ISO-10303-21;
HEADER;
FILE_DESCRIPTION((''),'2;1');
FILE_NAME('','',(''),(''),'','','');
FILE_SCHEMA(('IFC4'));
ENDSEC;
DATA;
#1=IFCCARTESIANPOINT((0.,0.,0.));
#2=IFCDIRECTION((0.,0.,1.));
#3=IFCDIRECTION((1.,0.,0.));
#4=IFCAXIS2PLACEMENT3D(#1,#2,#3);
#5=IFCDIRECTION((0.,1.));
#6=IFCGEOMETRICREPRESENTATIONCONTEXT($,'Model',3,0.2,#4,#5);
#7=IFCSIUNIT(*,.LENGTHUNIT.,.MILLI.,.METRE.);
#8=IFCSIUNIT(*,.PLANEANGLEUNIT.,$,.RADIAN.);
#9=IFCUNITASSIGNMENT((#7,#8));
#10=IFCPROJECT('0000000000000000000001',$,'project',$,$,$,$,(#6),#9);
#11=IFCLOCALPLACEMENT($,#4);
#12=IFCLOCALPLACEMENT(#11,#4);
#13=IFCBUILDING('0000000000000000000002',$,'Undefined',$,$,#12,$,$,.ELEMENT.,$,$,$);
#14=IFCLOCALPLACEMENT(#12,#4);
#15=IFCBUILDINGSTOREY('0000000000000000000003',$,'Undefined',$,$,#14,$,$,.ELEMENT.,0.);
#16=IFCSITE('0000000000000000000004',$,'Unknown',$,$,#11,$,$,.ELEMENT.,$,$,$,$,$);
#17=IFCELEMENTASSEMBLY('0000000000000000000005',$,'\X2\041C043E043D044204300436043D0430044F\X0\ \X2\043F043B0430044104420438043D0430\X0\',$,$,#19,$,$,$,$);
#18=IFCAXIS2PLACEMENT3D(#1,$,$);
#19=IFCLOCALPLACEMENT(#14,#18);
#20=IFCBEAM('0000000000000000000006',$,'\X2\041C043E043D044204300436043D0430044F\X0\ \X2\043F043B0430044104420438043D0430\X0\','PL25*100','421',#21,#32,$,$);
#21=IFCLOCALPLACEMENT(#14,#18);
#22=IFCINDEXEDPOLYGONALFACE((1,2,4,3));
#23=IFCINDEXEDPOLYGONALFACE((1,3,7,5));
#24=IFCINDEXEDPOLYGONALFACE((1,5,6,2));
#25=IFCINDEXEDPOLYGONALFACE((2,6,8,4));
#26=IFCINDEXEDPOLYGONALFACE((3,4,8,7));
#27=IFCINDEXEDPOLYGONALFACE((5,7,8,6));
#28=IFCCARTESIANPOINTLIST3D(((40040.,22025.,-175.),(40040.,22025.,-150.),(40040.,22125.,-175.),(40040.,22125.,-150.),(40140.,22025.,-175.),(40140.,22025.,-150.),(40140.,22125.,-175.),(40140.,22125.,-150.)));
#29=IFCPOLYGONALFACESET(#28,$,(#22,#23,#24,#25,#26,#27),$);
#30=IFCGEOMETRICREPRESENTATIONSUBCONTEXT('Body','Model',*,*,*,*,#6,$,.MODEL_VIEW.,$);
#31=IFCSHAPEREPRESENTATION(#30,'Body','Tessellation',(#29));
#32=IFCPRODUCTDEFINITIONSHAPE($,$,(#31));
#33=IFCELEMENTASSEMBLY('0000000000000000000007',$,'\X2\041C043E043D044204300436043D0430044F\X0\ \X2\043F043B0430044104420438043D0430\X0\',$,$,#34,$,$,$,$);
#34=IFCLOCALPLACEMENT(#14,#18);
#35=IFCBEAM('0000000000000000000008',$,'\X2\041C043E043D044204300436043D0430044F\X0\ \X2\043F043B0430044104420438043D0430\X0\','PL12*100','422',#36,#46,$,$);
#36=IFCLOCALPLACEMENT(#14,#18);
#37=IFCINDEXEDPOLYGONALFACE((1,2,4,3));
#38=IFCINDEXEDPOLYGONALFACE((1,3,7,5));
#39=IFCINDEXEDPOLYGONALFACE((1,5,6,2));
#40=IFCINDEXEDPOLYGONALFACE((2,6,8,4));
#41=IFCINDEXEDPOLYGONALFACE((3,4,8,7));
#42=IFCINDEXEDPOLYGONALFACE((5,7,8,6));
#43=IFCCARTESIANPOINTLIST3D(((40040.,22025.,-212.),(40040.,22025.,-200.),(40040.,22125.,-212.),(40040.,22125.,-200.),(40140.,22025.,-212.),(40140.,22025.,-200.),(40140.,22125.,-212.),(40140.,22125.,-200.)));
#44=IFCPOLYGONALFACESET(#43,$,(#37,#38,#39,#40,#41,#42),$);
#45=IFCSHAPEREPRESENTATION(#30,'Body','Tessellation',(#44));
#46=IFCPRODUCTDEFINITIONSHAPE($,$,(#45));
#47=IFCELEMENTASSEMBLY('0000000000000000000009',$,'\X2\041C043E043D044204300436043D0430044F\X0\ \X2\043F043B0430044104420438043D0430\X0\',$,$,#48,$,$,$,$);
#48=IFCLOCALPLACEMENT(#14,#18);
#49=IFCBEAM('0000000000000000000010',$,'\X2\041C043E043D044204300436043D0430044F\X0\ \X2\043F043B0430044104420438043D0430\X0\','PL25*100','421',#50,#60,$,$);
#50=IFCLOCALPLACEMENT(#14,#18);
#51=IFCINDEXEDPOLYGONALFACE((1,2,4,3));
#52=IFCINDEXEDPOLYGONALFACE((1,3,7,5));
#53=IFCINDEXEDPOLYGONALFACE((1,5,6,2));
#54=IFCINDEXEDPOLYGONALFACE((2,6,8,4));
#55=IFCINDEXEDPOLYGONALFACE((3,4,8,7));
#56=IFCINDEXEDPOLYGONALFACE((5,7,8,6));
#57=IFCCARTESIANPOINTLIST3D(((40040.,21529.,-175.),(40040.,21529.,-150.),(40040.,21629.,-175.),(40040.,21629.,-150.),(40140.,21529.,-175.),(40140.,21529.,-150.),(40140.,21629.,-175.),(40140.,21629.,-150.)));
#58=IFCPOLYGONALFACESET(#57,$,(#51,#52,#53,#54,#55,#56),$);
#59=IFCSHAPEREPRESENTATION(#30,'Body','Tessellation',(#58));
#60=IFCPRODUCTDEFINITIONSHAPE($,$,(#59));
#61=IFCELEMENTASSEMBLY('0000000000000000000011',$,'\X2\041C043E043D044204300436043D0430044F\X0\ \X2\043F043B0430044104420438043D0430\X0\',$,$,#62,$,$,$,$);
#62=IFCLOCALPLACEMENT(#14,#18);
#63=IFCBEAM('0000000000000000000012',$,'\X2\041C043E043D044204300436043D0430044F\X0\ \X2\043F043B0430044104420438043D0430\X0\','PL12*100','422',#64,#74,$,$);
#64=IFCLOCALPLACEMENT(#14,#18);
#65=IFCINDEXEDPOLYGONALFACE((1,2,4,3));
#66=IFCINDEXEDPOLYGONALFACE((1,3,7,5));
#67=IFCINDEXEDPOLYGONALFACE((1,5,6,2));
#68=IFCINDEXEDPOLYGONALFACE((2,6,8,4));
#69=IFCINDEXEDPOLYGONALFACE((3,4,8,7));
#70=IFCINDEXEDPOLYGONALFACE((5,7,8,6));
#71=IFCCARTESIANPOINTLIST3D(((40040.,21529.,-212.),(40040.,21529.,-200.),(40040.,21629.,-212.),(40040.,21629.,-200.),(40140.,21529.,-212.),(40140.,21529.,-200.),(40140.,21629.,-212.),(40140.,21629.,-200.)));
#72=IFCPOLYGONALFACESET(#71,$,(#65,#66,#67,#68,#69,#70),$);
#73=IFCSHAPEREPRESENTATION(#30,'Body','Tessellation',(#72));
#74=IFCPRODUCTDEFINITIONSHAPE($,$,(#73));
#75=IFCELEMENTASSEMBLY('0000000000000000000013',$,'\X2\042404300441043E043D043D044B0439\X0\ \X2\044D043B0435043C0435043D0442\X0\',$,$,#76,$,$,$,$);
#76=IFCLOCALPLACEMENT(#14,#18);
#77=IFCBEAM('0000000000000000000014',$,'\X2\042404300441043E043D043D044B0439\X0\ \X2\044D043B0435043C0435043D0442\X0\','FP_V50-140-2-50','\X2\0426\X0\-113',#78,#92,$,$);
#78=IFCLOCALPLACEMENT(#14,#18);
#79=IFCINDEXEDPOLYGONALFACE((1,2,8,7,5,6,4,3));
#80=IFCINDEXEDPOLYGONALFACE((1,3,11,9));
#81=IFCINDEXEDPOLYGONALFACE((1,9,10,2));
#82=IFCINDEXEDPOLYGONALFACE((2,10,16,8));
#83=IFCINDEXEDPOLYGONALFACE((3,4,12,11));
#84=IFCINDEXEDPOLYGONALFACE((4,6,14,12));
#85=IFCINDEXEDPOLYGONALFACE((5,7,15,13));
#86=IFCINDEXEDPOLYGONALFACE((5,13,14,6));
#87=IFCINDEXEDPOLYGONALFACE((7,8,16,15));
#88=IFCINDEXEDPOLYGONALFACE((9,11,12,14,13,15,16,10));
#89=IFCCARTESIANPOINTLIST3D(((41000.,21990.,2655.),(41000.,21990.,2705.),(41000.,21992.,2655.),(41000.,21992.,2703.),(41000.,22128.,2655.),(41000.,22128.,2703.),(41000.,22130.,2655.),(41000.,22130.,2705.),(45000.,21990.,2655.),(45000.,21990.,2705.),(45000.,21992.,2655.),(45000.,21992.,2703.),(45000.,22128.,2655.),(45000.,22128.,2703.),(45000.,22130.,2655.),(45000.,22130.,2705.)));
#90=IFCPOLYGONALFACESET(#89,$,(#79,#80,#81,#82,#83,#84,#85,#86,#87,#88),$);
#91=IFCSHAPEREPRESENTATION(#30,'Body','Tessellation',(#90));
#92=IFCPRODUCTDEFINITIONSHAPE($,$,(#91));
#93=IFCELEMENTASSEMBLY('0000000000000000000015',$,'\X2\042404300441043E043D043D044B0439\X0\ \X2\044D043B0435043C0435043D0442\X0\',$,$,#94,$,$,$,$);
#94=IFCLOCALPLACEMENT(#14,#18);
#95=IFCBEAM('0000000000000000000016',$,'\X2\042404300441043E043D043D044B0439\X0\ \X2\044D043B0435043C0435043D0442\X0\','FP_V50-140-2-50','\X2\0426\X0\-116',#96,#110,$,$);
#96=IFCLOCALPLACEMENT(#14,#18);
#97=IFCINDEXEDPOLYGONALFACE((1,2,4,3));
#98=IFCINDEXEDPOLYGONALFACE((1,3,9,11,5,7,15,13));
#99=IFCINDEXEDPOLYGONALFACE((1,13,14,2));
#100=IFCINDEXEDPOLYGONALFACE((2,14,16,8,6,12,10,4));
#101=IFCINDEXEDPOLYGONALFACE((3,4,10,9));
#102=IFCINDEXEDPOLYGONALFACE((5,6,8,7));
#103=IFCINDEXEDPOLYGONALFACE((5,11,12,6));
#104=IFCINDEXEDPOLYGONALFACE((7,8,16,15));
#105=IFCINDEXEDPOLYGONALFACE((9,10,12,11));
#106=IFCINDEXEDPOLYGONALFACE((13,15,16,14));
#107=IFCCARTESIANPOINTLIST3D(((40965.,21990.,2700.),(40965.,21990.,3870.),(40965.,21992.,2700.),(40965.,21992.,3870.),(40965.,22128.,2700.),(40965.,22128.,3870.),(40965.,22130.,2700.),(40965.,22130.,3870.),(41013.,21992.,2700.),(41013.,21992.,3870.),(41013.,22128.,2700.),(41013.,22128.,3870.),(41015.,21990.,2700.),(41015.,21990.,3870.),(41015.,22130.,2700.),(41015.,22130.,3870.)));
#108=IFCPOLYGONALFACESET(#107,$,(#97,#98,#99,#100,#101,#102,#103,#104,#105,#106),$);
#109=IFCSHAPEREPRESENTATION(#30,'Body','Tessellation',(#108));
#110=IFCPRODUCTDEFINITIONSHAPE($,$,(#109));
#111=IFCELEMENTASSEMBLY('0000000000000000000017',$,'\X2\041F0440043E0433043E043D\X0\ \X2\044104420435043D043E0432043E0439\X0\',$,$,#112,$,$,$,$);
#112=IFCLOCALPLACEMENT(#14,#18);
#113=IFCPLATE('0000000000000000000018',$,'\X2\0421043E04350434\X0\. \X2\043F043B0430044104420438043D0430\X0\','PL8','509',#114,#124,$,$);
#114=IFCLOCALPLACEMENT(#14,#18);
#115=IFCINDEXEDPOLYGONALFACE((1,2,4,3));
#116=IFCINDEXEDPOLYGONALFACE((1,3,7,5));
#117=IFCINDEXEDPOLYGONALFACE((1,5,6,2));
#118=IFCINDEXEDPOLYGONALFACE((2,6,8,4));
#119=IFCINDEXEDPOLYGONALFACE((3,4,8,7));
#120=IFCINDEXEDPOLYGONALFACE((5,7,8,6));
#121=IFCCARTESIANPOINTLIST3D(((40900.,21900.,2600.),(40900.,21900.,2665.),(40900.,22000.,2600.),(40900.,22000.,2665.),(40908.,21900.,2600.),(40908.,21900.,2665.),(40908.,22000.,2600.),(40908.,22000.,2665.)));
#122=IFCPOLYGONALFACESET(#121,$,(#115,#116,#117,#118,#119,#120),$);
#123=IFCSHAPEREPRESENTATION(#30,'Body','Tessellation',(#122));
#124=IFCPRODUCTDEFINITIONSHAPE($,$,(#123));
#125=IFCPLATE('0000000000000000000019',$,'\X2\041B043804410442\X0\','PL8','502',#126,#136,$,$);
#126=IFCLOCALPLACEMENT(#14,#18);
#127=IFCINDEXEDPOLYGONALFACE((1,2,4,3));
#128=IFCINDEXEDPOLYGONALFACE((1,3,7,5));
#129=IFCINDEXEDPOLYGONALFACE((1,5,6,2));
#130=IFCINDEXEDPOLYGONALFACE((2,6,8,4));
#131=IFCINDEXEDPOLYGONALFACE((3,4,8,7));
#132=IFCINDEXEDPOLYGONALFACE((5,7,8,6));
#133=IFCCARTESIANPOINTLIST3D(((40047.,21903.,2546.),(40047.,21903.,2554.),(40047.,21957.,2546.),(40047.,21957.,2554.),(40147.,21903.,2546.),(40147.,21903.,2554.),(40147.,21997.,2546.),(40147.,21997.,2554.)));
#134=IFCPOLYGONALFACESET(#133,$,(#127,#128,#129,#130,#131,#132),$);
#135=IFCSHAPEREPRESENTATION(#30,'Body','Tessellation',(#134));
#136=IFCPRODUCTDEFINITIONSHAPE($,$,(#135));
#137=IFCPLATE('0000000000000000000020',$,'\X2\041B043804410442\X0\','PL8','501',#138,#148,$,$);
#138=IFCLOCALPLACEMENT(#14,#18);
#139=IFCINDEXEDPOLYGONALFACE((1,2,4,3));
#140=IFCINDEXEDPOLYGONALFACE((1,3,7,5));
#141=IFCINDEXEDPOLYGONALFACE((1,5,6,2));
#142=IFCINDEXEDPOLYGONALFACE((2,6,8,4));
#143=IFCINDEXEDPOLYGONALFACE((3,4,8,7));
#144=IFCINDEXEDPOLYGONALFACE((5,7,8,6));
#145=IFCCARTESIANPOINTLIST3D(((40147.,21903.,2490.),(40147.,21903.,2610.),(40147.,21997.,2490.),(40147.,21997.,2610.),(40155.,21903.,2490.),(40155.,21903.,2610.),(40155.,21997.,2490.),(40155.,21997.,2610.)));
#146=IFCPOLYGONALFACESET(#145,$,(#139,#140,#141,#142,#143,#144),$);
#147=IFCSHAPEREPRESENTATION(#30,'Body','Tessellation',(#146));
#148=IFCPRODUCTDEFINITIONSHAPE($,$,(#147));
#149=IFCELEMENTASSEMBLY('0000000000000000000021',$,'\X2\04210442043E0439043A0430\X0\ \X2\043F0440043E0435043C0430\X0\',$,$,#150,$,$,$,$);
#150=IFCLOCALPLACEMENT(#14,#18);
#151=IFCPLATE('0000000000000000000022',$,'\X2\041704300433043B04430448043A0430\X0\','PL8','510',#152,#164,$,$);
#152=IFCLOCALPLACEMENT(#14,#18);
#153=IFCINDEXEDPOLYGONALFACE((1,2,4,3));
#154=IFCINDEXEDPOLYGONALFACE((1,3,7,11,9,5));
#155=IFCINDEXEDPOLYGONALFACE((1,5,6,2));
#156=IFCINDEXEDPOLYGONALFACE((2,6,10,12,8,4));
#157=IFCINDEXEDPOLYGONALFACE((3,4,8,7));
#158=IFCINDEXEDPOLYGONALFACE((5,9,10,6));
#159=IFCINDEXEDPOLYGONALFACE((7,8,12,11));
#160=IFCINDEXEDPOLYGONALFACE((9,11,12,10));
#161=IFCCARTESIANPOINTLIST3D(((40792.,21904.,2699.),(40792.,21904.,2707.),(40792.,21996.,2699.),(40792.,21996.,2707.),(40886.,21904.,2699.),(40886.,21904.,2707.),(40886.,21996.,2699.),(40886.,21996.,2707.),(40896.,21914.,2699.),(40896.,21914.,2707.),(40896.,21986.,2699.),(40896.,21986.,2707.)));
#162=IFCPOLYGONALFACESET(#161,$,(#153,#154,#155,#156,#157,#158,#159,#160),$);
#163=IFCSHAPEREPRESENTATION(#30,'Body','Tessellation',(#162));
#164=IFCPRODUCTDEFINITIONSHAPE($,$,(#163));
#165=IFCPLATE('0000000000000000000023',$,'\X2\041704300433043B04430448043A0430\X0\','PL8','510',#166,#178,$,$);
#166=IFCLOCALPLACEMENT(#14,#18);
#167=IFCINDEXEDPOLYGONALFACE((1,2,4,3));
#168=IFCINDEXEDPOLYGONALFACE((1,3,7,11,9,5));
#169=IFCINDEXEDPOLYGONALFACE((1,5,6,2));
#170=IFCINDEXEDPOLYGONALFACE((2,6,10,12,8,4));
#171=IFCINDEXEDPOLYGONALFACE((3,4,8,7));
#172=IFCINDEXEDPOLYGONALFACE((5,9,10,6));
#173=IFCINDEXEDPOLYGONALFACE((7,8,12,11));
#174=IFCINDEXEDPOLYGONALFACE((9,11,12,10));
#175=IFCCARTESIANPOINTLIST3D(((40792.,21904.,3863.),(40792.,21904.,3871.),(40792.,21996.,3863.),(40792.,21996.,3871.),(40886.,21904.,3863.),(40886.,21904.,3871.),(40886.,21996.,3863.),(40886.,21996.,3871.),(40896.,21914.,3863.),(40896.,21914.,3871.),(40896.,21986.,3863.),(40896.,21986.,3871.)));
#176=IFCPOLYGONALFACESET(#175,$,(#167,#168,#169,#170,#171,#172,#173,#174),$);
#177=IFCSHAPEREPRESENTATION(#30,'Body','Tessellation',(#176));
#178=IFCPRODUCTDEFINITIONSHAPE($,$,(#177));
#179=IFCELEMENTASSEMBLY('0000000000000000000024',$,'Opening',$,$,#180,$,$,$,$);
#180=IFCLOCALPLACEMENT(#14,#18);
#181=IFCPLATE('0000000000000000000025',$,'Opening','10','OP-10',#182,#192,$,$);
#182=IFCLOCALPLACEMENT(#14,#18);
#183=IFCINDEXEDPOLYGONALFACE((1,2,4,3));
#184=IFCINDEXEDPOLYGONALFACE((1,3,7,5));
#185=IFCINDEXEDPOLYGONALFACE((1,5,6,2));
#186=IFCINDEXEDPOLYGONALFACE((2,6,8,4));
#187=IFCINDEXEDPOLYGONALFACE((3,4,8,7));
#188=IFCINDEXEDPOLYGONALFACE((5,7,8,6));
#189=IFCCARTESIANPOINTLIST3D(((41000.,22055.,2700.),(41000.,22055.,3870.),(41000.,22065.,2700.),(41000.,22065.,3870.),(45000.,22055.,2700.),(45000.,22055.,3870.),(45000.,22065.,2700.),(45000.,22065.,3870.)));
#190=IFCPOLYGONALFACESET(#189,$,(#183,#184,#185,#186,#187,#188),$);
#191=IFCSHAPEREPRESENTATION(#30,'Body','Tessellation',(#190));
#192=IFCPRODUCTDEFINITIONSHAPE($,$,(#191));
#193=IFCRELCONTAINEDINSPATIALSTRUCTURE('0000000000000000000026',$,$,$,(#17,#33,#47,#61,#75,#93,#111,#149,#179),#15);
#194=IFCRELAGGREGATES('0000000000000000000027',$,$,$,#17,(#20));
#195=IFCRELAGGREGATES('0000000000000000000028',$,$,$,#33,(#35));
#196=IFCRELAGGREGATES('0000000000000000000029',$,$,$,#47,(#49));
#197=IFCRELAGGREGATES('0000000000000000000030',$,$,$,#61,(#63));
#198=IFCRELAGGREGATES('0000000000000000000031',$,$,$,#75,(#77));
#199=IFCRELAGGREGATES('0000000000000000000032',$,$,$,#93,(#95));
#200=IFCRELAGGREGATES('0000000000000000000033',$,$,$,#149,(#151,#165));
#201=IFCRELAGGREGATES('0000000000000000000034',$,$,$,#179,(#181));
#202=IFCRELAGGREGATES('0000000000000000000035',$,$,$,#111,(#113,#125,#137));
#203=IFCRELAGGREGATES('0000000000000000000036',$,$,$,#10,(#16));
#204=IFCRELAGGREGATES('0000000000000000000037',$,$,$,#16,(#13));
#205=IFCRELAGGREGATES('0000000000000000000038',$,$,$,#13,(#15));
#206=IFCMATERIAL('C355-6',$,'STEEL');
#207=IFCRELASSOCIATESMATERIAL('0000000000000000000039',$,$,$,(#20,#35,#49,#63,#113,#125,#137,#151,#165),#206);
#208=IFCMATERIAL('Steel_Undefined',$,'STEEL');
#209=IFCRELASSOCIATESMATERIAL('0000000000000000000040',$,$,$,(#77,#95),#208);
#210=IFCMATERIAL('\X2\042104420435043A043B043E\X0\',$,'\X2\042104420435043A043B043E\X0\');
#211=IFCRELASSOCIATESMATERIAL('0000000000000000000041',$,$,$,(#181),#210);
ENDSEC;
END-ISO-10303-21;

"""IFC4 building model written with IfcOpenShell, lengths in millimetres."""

from ifc_helpers import new_model, si_unit, direction, frame, origin_with_axes, place, context, subcontext, project, spatial, line, indexed_curve, outline, extrude, material, element, aggregate, save


model = new_model("IFC4")

# Units and contexts
model_context = context("Model", 3, precision=0.2, world=origin_with_axes(), true_north=direction((0.0, 1.0)))
body_context = subcontext(model_context, "Body", "Model", "MODEL_VIEW")
ifc_project = project(units=[si_unit("LENGTHUNIT", "METRE", prefix="MILLI"), si_unit("PLANEANGLEUNIT", "RADIAN")], contexts=[model_context])

# Site, building, storey
site_placement = place(None, origin_with_axes())
site = spatial("IfcSite", under=ifc_project, at=site_placement, Name="Unknown", CompositionType="ELEMENT")
building_placement = place(site_placement, origin_with_axes())
building = spatial("IfcBuilding", under=site, at=building_placement, Name="Undefined", CompositionType="ELEMENT")
storey_placement = place(building_placement, origin_with_axes())
storey = spatial("IfcBuildingStorey", under=building, at=storey_placement, Name="Undefined", CompositionType="ELEMENT", Elevation=0.0)

# Shared definitions
ifc_material_1 = material(Name="Steel_Undefined", Category="STEEL")

# Element assemblies, beams
assembly_1_placement = place(storey_placement, frame((40140.0, 22075.0, -162.5), z_axis=(0.0, 0.0, -1.0), x_axis=(-1.0, 0.0, 0.0)))
assembly_1 = element("IfcElementAssembly", 1, at=assembly_1_placement, inside=storey, Name="Монтажная пластина")
ifc_material_2 = material(Name="C355-6", Category="STEEL")
beam_1_placement = place(assembly_1_placement, origin_with_axes())
beam_1 = element("IfcBeam", 2, at=beam_1_placement, material=ifc_material_2, Name="Монтажная пластина", Description="PL25*100", ObjectType="421", context=body_context, shape_type="SolidModel", body=[
    extrude(outline(indexed_curve([(-12.5, -50.0), (12.5, -50.0), (12.5, 50.0), (-12.5, 50.0)], segments=[line(1, 2, 3, 4, 1)])), frame((0.0, 0.0, 0.0), z_axis=(-1.0, 0.0, 0.0), x_axis=(0.0, 0.0, 1.0)), (0.0, 0.0, -1.0), 100.0),
])
aggregate(assembly_1, [beam_1])
assembly_2_placement = place(storey_placement, frame((40140.0, 22075.0, -206.0), z_axis=(0.0, 0.0, -1.0), x_axis=(-1.0, 0.0, 0.0)))
assembly_2 = element("IfcElementAssembly", 3, at=assembly_2_placement, inside=storey, Name="Монтажная пластина")
beam_2_placement = place(assembly_2_placement, origin_with_axes())
beam_2 = element("IfcBeam", 4, at=beam_2_placement, material=ifc_material_2, Name="Монтажная пластина", Description="PL12*100", ObjectType="422", context=body_context, shape_type="SolidModel", body=[
    extrude(outline(indexed_curve([(-6.0, -50.0), (6.0, -50.0), (6.0, 50.0), (-6.0, 50.0)], segments=[line(1, 2, 3, 4, 1)])), frame((0.0, 0.0, 0.0), z_axis=(-1.0, 0.0, 0.0), x_axis=(0.0, 0.0, 1.0)), (0.0, 0.0, -1.0), 100.0),
])
aggregate(assembly_2, [beam_2])
assembly_3_placement = place(storey_placement, frame((40140.0, 21579.0, -162.5), z_axis=(0.0, 0.0, -1.0), x_axis=(-1.0, 0.0, 0.0)))
assembly_3 = element("IfcElementAssembly", 5, at=assembly_3_placement, inside=storey, Name="Монтажная пластина")
beam_3_placement = place(assembly_3_placement, origin_with_axes())
beam_3 = element("IfcBeam", 6, at=beam_3_placement, material=ifc_material_2, Name="Монтажная пластина", Description="PL25*100", ObjectType="421", context=body_context, shape_type="SolidModel", body=[
    extrude(outline(indexed_curve([(-12.5, -50.0), (12.5, -50.0), (12.5, 50.0), (-12.5, 50.0)], segments=[line(1, 2, 3, 4, 1)])), frame((0.0, 0.0, 0.0), z_axis=(-1.0, 0.0, 0.0), x_axis=(0.0, 0.0, 1.0)), (0.0, 0.0, -1.0), 100.0),
])
aggregate(assembly_3, [beam_3])
assembly_4_placement = place(storey_placement, frame((40140.0, 21579.0, -206.0), z_axis=(0.0, 0.0, -1.0), x_axis=(-1.0, 0.0, 0.0)))
assembly_4 = element("IfcElementAssembly", 7, at=assembly_4_placement, inside=storey, Name="Монтажная пластина")
beam_4_placement = place(assembly_4_placement, origin_with_axes())
beam_4 = element("IfcBeam", 8, at=beam_4_placement, material=ifc_material_2, Name="Монтажная пластина", Description="PL12*100", ObjectType="422", context=body_context, shape_type="SolidModel", body=[
    extrude(outline(indexed_curve([(-6.0, -50.0), (6.0, -50.0), (6.0, 50.0), (-6.0, 50.0)], segments=[line(1, 2, 3, 4, 1)])), frame((0.0, 0.0, 0.0), z_axis=(-1.0, 0.0, 0.0), x_axis=(0.0, 0.0, 1.0)), (0.0, 0.0, -1.0), 100.0),
])
aggregate(assembly_4, [beam_4])
assembly_5_placement = place(storey_placement, frame((45000.0, 22060.0, 2680.0), z_axis=(0.0, 1.0, 0.0), x_axis=(-1.0, 0.0, 0.0)))
assembly_5 = element("IfcElementAssembly", 9, at=assembly_5_placement, inside=storey, Name="Фасонный элемент")
beam_5_placement = place(assembly_5_placement, origin_with_axes())
beam_5 = element("IfcBeam", 10, at=beam_5_placement, material=ifc_material_1, Name="Фасонный элемент", Description="FP_V50-140-2-50", ObjectType="Ц-113", context=body_context, shape_type="SolidModel", body=[
    extrude(outline(indexed_curve([(-70.0, -25.0), (-68.0, -25.0), (-68.0, 23.0), (68.0, 23.0), (68.0, -25.0), (70.0, -25.0), (70.0, 25.0), (-70.0, 25.0)], segments=[line(1, 2, 3, 4, 5, 6, 7, 8, 1)])), frame((0.0, 0.0, 0.0), z_axis=(-1.0, 0.0, 0.0), x_axis=(0.0, 0.0, 1.0)), (0.0, 0.0, -1.0), 4000.0),
])
aggregate(assembly_5, [beam_5])
assembly_6_placement = place(storey_placement, frame((40990.0, 22060.0, 3870.0), z_axis=(0.0, -1.0, 0.0), x_axis=(0.0, 0.0, -1.0)))
assembly_6 = element("IfcElementAssembly", 11, at=assembly_6_placement, inside=storey, Name="Фасонный элемент")
beam_6_placement = place(assembly_6_placement, origin_with_axes())
beam_6 = element("IfcBeam", 12, at=beam_6_placement, material=ifc_material_1, Name="Фасонный элемент", Description="FP_V50-140-2-50", ObjectType="Ц-116", context=body_context, shape_type="SolidModel", body=[
    extrude(outline(indexed_curve([(-70.0, -25.0), (-68.0, -25.0), (-68.0, 23.0), (68.0, 23.0), (68.0, -25.0), (70.0, -25.0), (70.0, 25.0), (-70.0, 25.0)], segments=[line(1, 2, 3, 4, 5, 6, 7, 8, 1)])), frame((0.0, 0.0, 0.0), z_axis=(-1.0, 0.0, 0.0), x_axis=(0.0, 0.0, 1.0)), (0.0, 0.0, -1.0), 1170.0),
])
aggregate(assembly_6, [beam_6])

# Element assemblies, plates
assembly_7_placement = place(storey_placement, frame((46000.0, 21950.0, 2550.0), z_axis=(0.0, 0.0, -1.0), x_axis=(-1.0, 0.0, 0.0)))
assembly_7 = element("IfcElementAssembly", 13, at=assembly_7_placement, inside=storey, Name="Прогон стеновой")
plate_1_placement = place(assembly_7_placement, frame((5096.0, 50.0, -50.0), z_axis=(-1.0, 0.0, 0.0), x_axis=(0.0, 0.0, -1.0)))
plate_1 = element("IfcPlate", 14, at=plate_1_placement, material=ifc_material_2, Name="Соед. пластина", Description="PL8", ObjectType="509", context=body_context, shape_type="SolidModel", body=[
    extrude(outline(indexed_curve([(0.0, 0.0), (65.0, 0.0), (65.0, 100.0), (0.0, 100.0)], segments=[line(1, 2, 3, 4, 1)])), frame((0.0, 0.0, 4.0), z_axis=(0.0, 0.0, 1.0), x_axis=(1.0, 0.0, 0.0)), (0.0, 0.0, -1.0), 8.0),
])
plate_2_placement = place(assembly_7_placement, frame((5853.0, 47.0, 0.0), z_axis=(0.0, 0.0, 1.0), x_axis=(0.0, -1.0, 0.0)))
plate_2 = element("IfcPlate", 15, at=plate_2_placement, material=ifc_material_2, Name="Лист", Description="PL8", ObjectType="502", context=body_context, shape_type="SolidModel", body=[
    extrude(outline(indexed_curve([(0.0, 0.0), (94.0, 0.0), (94.0, 100.0), (40.0, 100.0), (0.0, 0.0)], segments=[line(1, 2, 3, 4, 5, 1)])), frame((0.0, 0.0, 4.0), z_axis=(0.0, 0.0, 1.0), x_axis=(1.0, 0.0, 0.0)), (0.0, 0.0, -1.0), 8.0),
])
plate_3_placement = place(assembly_7_placement, frame((5849.0, 47.0, -60.0), z_axis=(-1.0, 0.0, 0.0), x_axis=(0.0, -1.0, 0.0)))
plate_3 = element("IfcPlate", 16, at=plate_3_placement, material=ifc_material_2, Name="Лист", Description="PL8", ObjectType="501", context=body_context, shape_type="SolidModel", body=[
    extrude(outline(indexed_curve([(0.0, 0.0), (94.0, 0.0), (94.0, 120.0), (0.0, 120.0)], segments=[line(1, 2, 3, 4, 1)])), frame((0.0, 0.0, 4.0), z_axis=(0.0, 0.0, 1.0), x_axis=(1.0, 0.0, 0.0)), (0.0, 0.0, -1.0), 8.0),
])
assembly_8_placement = place(storey_placement, frame((40850.0, 21950.0, 2600.0), z_axis=(-1.0, 0.0, 0.0), x_axis=(0.0, 0.0, 1.0)))
assembly_8 = element("IfcElementAssembly", 17, at=assembly_8_placement, inside=storey, Name="Стойка проема")
plate_4_placement = place(assembly_8_placement, frame((103.0, 46.0, -46.0), z_axis=(-1.0, 0.0, 0.0), x_axis=(0.0, -1.0, 0.0)))
plate_4 = element("IfcPlate", 18, at=plate_4_placement, material=ifc_material_2, Name="Заглушка", Description="PL8", ObjectType="510", context=body_context, shape_type="SolidModel", body=[
    extrude(outline(indexed_curve([(0.0, 10.0), (10.0, 0.0), (82.0, 0.0), (92.0, 10.0), (92.0, 104.0), (0.0, 104.0)], segments=[line(1, 2, 3, 4, 5, 6, 1)])), frame((0.0, 0.0, 4.0), z_axis=(0.0, 0.0, 1.0), x_axis=(1.0, 0.0, 0.0)), (0.0, 0.0, -1.0), 8.0),
])
plate_5_placement = place(assembly_8_placement, frame((1267.0, -46.0, -46.0), z_axis=(1.0, 0.0, 0.0), x_axis=(0.0, 1.0, 0.0)))
plate_5 = element("IfcPlate", 19, at=plate_5_placement, material=ifc_material_2, Name="Заглушка", Description="PL8", ObjectType="510", context=body_context, shape_type="SolidModel", body=[
    extrude(outline(indexed_curve([(0.0, 10.0), (10.0, 0.0), (82.0, 0.0), (92.0, 10.0), (92.0, 104.0), (0.0, 104.0)], segments=[line(1, 2, 3, 4, 5, 6, 1)])), frame((0.0, 0.0, 4.0), z_axis=(0.0, 0.0, 1.0), x_axis=(1.0, 0.0, 0.0)), (0.0, 0.0, -1.0), 8.0),
])
aggregate(assembly_8, [plate_4, plate_5])

# Element assembly, plate
assembly_9_placement = place(storey_placement, frame((41000.0, 22060.0, 2700.0), z_axis=(0.0, -1.0, 0.0), x_axis=(1.0, 0.0, 0.0)))
assembly_9 = element("IfcElementAssembly", 20, at=assembly_9_placement, inside=storey, Name="Opening")
ifc_material_3 = material(Name="Стекло", Category="Стекло")
plate_6_placement = place(assembly_9_placement, origin_with_axes())
plate_6 = element("IfcPlate", 21, at=plate_6_placement, material=ifc_material_3, Name="Opening", Description="10", ObjectType="OP-10", context=body_context, shape_type="SolidModel", body=[
    extrude(outline(indexed_curve([(0.0, 0.0), (4000.0, 0.0), (4000.0, 1170.0), (0.0, 1170.0)], segments=[line(1, 2, 3, 4, 1)])), frame((0.0, 0.0, 5.0), z_axis=(0.0, 0.0, 1.0), x_axis=(1.0, 0.0, 0.0)), (0.0, 0.0, -1.0), 10.0),
])
aggregate(assembly_9, [plate_6])

aggregate(assembly_7, [plate_1, plate_2, plate_3])

save(model, "model.ifc")
